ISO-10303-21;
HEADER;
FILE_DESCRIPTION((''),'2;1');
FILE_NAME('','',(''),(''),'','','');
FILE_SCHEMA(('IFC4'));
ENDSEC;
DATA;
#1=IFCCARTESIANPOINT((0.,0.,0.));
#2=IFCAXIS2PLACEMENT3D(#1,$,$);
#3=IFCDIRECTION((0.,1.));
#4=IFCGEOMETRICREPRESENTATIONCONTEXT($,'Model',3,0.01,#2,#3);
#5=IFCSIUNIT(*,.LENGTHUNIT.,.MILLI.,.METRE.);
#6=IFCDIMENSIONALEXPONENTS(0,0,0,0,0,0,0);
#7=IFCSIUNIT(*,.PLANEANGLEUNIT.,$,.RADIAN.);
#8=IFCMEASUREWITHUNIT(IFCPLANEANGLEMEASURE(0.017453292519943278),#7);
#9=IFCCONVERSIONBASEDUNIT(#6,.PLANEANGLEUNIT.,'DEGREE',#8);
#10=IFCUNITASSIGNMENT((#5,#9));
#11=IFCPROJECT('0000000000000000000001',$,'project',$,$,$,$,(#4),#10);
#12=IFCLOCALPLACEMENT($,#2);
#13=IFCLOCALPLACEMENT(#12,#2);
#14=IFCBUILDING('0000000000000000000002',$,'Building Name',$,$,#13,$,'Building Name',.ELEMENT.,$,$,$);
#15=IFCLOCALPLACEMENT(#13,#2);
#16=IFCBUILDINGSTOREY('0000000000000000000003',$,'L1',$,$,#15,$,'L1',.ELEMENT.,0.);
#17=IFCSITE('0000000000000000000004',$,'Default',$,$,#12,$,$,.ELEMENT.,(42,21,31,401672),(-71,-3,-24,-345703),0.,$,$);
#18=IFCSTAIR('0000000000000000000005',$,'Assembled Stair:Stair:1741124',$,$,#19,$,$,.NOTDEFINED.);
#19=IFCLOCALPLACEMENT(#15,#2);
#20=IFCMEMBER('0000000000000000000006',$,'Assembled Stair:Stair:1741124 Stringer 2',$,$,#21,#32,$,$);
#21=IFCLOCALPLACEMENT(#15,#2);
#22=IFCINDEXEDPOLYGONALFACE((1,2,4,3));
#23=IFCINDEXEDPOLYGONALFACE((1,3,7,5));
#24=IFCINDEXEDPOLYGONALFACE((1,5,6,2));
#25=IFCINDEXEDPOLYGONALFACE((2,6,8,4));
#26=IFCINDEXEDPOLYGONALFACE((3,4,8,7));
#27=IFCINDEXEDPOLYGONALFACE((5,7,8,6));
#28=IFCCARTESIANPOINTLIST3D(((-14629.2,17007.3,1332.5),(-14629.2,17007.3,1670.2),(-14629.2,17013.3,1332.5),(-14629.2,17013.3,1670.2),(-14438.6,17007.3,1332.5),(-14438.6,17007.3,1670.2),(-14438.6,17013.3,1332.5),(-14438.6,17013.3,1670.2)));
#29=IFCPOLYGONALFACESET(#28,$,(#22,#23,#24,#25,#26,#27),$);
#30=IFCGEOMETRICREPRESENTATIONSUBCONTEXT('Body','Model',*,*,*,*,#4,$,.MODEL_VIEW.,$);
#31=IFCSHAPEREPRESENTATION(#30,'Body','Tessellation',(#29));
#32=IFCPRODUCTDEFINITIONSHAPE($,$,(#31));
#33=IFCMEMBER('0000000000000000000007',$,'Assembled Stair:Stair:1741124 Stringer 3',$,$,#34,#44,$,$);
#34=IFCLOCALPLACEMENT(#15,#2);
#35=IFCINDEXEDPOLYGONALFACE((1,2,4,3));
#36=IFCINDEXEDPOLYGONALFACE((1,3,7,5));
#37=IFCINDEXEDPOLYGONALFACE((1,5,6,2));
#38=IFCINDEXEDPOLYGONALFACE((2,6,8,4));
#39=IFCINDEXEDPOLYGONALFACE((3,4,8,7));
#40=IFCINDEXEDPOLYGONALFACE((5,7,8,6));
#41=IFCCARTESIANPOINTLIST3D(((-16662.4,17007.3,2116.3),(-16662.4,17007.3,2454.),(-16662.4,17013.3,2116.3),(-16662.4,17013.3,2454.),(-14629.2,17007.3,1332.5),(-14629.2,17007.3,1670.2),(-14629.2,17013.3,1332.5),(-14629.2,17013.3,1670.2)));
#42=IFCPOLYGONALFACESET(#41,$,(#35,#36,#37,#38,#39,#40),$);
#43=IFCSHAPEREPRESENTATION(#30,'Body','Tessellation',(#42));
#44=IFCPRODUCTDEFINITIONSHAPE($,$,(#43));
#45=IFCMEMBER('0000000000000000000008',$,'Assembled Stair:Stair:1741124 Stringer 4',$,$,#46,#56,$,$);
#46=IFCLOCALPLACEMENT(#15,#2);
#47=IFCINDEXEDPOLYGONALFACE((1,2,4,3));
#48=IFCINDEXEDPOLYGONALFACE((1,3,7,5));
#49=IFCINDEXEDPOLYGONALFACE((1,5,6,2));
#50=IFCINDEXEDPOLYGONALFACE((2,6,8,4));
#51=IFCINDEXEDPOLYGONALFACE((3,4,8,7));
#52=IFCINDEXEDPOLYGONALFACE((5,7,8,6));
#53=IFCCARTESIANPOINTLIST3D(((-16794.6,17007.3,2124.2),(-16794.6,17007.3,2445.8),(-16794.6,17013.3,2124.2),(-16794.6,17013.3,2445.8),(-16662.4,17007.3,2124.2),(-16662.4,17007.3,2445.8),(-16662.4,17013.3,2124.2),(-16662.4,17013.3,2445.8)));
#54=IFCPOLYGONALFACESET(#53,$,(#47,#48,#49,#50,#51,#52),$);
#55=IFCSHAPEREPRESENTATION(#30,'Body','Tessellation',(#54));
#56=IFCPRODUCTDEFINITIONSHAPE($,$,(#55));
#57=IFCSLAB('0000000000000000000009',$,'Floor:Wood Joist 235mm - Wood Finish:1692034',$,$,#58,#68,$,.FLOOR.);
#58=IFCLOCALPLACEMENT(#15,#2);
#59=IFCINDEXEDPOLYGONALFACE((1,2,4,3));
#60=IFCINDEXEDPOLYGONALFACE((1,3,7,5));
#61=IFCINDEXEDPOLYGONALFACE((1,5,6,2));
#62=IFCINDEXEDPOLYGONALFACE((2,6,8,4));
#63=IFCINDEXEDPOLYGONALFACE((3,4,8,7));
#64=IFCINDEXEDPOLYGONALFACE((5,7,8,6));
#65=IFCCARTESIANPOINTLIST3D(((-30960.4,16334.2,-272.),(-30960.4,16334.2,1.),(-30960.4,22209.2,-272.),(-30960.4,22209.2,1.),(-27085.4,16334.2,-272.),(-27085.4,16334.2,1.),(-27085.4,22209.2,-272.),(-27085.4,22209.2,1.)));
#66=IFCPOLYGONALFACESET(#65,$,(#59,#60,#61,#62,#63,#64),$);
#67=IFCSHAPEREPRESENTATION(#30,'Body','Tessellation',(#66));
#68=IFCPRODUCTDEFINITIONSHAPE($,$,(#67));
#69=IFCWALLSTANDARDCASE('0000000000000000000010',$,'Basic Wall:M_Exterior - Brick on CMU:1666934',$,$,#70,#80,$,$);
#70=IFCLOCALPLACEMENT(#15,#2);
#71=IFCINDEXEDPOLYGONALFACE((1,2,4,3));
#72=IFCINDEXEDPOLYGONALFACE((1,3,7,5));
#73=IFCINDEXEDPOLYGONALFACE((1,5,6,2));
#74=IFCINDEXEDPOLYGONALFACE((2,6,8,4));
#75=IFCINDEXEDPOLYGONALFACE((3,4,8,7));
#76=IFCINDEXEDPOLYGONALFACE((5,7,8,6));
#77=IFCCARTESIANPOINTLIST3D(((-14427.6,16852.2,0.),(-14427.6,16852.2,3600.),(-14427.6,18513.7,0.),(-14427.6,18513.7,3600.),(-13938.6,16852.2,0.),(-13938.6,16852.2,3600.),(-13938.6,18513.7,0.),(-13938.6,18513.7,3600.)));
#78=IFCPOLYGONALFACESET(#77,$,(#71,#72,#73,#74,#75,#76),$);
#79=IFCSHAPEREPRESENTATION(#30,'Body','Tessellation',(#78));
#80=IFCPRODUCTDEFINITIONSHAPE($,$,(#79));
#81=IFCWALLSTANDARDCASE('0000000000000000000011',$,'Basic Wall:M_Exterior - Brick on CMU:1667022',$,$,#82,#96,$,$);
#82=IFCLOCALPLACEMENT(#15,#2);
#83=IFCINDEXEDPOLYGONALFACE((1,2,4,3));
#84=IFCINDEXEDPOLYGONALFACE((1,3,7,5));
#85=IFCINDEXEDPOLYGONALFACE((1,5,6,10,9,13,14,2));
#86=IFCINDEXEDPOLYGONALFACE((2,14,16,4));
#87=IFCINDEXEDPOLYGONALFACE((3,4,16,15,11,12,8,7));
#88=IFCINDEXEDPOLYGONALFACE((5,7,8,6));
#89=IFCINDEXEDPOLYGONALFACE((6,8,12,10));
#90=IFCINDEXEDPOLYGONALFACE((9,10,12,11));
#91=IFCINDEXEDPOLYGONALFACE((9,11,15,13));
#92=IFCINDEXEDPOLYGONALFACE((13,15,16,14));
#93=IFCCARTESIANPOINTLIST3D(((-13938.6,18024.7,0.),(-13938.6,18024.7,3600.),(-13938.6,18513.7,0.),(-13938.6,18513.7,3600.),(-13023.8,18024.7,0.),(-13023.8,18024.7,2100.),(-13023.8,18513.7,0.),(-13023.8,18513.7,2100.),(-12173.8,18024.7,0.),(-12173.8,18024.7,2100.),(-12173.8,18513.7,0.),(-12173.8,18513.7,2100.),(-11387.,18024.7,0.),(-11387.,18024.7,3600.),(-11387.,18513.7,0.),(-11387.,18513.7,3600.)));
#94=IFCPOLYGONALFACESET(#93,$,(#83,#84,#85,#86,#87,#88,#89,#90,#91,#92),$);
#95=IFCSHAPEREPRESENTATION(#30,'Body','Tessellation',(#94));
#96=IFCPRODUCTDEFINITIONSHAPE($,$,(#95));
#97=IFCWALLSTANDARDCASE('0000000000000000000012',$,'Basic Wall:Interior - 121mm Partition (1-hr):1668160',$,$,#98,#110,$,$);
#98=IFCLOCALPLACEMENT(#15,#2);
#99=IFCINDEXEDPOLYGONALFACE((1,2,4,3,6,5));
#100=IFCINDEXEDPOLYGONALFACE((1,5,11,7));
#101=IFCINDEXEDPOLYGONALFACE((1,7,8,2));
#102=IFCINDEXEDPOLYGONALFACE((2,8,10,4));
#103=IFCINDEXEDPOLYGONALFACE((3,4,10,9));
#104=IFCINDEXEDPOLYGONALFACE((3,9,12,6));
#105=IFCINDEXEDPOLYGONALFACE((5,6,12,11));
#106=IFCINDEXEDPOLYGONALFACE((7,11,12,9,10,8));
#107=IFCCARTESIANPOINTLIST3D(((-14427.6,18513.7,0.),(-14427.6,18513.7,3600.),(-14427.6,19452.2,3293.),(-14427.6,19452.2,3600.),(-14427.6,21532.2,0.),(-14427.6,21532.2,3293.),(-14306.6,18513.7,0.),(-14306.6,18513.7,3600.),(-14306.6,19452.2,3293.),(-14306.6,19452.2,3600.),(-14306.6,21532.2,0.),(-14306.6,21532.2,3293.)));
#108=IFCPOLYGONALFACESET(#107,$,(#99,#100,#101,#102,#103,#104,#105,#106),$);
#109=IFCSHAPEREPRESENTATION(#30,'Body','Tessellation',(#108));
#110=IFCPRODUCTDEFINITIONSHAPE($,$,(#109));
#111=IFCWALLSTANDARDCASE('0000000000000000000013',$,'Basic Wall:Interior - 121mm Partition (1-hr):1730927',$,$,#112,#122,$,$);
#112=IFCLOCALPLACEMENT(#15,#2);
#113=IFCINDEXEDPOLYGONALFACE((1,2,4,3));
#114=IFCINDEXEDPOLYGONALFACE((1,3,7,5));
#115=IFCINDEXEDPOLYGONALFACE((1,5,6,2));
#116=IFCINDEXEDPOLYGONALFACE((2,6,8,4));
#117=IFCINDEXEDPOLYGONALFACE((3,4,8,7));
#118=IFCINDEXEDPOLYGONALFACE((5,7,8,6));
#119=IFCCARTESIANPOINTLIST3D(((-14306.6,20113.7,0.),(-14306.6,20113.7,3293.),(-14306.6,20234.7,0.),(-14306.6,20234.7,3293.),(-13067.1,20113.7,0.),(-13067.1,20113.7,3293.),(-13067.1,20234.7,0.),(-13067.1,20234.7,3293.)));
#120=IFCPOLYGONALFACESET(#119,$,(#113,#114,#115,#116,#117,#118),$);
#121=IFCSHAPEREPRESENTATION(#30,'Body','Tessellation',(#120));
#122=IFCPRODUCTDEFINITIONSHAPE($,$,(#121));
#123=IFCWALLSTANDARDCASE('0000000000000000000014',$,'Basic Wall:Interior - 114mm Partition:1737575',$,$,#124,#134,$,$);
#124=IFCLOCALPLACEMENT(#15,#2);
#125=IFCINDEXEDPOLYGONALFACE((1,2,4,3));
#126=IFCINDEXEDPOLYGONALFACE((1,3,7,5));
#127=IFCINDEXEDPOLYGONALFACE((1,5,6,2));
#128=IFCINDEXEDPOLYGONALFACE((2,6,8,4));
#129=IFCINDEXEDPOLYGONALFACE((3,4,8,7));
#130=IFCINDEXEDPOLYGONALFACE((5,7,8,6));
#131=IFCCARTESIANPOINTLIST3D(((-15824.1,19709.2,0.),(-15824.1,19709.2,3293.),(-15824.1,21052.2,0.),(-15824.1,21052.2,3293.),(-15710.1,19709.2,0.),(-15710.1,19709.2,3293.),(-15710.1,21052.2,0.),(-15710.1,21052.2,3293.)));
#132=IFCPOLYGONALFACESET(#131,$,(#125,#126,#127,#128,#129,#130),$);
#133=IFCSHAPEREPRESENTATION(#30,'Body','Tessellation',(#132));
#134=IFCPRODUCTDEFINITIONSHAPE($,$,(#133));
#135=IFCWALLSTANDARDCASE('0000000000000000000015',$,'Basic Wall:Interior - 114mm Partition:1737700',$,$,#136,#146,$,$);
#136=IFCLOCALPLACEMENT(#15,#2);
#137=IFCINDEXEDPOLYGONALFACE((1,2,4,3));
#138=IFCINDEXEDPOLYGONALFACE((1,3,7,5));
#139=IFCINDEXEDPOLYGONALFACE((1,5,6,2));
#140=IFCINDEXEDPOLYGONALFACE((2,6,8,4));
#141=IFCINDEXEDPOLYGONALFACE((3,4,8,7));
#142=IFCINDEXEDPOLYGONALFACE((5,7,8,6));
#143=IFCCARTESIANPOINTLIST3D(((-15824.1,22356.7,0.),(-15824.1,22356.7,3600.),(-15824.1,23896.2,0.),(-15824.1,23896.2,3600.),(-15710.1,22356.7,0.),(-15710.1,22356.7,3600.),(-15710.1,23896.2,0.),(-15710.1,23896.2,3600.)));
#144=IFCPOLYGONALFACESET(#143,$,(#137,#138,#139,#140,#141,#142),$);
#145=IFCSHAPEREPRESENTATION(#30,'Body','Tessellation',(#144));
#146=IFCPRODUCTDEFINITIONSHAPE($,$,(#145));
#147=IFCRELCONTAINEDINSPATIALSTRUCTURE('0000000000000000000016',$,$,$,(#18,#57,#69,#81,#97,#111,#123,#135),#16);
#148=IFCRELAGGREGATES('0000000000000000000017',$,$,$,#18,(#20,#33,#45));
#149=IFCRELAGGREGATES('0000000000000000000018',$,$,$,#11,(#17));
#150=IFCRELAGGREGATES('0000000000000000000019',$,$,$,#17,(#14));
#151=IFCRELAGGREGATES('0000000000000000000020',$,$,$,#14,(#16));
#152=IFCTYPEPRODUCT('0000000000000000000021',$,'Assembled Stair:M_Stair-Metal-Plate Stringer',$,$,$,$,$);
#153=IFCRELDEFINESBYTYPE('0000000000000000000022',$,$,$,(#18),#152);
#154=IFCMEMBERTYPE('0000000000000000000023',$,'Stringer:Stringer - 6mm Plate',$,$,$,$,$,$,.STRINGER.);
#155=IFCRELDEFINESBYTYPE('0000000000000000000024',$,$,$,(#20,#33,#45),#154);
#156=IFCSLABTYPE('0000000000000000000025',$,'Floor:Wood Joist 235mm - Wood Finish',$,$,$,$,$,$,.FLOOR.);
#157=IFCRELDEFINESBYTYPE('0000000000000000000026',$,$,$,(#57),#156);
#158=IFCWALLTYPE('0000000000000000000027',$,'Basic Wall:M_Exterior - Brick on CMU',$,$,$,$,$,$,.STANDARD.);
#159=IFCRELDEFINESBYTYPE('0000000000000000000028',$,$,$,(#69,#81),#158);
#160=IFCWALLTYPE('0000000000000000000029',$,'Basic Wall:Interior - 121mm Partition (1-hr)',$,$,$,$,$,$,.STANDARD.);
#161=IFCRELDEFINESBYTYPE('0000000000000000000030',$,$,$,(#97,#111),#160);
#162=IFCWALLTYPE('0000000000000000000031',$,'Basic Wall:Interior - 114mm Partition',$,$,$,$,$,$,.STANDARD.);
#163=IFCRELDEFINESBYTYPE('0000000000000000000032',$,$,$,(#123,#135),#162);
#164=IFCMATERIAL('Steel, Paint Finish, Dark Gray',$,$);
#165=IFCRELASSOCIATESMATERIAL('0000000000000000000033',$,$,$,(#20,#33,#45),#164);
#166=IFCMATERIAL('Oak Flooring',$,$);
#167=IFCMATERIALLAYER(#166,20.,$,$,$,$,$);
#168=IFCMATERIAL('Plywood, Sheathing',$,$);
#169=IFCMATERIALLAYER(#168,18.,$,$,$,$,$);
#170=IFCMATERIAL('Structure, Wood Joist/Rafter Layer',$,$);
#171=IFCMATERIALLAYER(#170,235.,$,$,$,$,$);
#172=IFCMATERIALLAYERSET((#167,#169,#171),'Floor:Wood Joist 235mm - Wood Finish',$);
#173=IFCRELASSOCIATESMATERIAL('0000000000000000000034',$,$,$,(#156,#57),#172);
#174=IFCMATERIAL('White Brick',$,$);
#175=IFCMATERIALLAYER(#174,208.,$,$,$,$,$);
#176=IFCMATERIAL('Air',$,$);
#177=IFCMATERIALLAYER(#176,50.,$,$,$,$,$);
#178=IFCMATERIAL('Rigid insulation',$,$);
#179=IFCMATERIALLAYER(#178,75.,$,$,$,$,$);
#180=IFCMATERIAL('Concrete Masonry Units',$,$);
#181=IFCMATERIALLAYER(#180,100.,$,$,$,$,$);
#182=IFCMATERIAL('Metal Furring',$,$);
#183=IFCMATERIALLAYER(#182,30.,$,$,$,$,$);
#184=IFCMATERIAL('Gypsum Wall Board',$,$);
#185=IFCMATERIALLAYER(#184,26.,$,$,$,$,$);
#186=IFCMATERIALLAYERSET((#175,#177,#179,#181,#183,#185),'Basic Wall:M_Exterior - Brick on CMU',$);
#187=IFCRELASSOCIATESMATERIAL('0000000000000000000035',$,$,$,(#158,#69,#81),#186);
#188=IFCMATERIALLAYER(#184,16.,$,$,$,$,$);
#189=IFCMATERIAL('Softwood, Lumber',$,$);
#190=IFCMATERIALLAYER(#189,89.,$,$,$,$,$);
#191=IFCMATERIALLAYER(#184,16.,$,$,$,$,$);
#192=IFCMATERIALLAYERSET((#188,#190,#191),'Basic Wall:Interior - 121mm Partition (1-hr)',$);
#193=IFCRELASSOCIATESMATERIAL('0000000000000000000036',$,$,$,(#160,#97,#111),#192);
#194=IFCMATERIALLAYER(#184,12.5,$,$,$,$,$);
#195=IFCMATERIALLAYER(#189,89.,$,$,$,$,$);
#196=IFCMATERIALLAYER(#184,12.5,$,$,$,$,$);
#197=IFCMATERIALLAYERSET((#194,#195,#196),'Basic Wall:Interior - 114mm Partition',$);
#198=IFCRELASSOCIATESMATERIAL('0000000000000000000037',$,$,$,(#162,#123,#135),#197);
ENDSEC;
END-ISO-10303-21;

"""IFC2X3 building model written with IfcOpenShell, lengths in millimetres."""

from ifc_helpers import new_model, entity, si_unit, converted_unit, direction, frame, frame_2d, origin, place, context, subcontext, project, spatial, polyline, rectangle, outline, extrude, clip, bounded_halfspace, material, layer, layer_set, layer_usage, type_object, element, aggregate, save


model = new_model("IFC2X3")

# Units and contexts
model_context = context("Model", 3, precision=0.01, world=origin(), true_north=direction((0.0, 1.0)))
body_context = subcontext(model_context, "Body", "Model", "MODEL_VIEW")
ifc_project = project(units=[si_unit("LENGTHUNIT", "METRE", prefix="MILLI"), converted_unit("PLANEANGLEUNIT", "DEGREE", entity("IfcPlaneAngleMeasure", 0.017453292519943278), si_unit("PLANEANGLEUNIT", "RADIAN"), dimensions=[0, 0, 0, 0, 0, 0, 0])], contexts=[model_context])

# Site, building, storey
site_placement = place(None, origin())
site = spatial("IfcSite", under=ifc_project, at=site_placement, Name="Default", CompositionType="ELEMENT", RefLatitude=(42, 21, 31, 401672), RefLongitude=(-71, -3, -24, -345703), RefElevation=0.0)
building_placement = place(site_placement, origin())
building = spatial("IfcBuilding", under=site, at=building_placement, Name="Building Name", LongName="Building Name", CompositionType="ELEMENT")
storey_placement = place(building_placement, origin())
storey = spatial("IfcBuildingStorey", under=building, at=storey_placement, Name="L1", LongName="L1", CompositionType="ELEMENT", Elevation=0.0)

# Stair, members
type_product = type_object("IfcTypeProduct", Name="Assembled Stair:M_Stair-Metal-Plate Stringer")
stair_placement = place(storey_placement, origin())
stair = element("IfcStair", 1, at=stair_placement, inside=storey, type_object=type_product, Name="Assembled Stair:Stair:1741124", ShapeType="NOTDEFINED")
ifc_material_1 = material(Name="Steel, Paint Finish, Dark Gray")
member_type = type_object("IfcMemberType", Name="Stringer:Stringer - 6mm Plate", PredefinedType="STRINGER")
member_1_placement = place(stair_placement, origin())
member_1 = element("IfcMember", 2, at=member_1_placement, type_object=member_type, material=ifc_material_1, Name="Assembled Stair:Stair:1741124 Stringer 2", context=body_context, shape_type="SweptSolid", body=[
    extrude(rectangle(XDim=190.6, YDim=6.0, at=frame_2d((0.0, 0.0), x_axis=(1.0, 0.0))), frame((-14533.9, 17010.3, 1332.5), z_axis=(0.0, 0.0, 1.0), x_axis=(-1.0, 0.0, 0.0)), (0.0, 0.0, 1.0), 337.7),
])
member_2_placement = place(stair_placement, origin())
member_2 = element("IfcMember", 3, at=member_2_placement, type_object=member_type, material=ifc_material_1, Name="Assembled Stair:Stair:1741124 Stringer 3", context=body_context, shape_type="SweptSolid", body=[
    extrude(outline(polyline([(-1150.2, -157.5), (1028.8, -157.5), (1150.2, 157.5), (-1028.8, 157.5), (-1150.2, -157.5)])), frame((-15645.8, 17007.3, 1893.3), z_axis=(0.0, 1.0, 0.0), x_axis=(-0.933076, 0.0, 0.35968)), (0.0, 0.0, 1.0), 6.0),
])
member_3_placement = place(stair_placement, origin())
member_3 = element("IfcMember", 4, at=member_3_placement, type_object=member_type, material=ifc_material_1, Name="Assembled Stair:Stair:1741124 Stringer 4", context=body_context, shape_type="SweptSolid", body=[
    extrude(rectangle(XDim=132.2, YDim=6.0, at=frame_2d((0.0, 0.0), x_axis=(1.0, 0.0))), frame((-16728.5, 17010.3, 2124.2), z_axis=(0.0, 0.0, 1.0), x_axis=(-1.0, 0.0, 0.0)), (0.0, 0.0, 1.0), 321.5),
])
aggregate(stair, [member_1, member_2, member_3])

# Slab
ifc_material_2 = material(Name="Oak Flooring")
ifc_layer_1 = layer(ifc_material_2, 20.0)
ifc_material_3 = material(Name="Plywood, Sheathing")
ifc_layer_2 = layer(ifc_material_3, 18.0)
ifc_material_4 = material(Name="Structure, Wood Joist/Rafter Layer")
ifc_layer_3 = layer(ifc_material_4, 235.0)
ifc_layer_set_1 = layer_set([ifc_layer_1, ifc_layer_2, ifc_layer_3], Name="Floor:Wood Joist 235mm - Wood Finish")
ifc_layer_usage_1 = layer_usage(ifc_layer_set_1, "AXIS3", "POSITIVE", 0.0)
slab_type_1 = type_object("IfcSlabType", Name="Floor:Wood Joist 235mm - Wood Finish", PredefinedType="FLOOR", material=ifc_layer_set_1)
slab_1_placement = place(storey_placement, origin())
element("IfcSlab", 5, at=slab_1_placement, inside=storey, type_object=slab_type_1, material=ifc_layer_usage_1, Name="Floor:Wood Joist 235mm - Wood Finish:1692034", PredefinedType="FLOOR", context=body_context, shape_type="SweptSolid", body=[
    extrude(rectangle(XDim=5875.0, YDim=3875.0, at=frame_2d((0.0, 0.0), x_axis=(1.0, 0.0))), frame((-29022.9, 19271.7, 1.0), z_axis=(0.0, 0.0, -1.0), x_axis=(0.0, 1.0, 0.0)), (0.0, 0.0, 1.0), 273.0),
])

# Wall
ifc_material_5 = material(Name="White Brick")
ifc_layer_4 = layer(ifc_material_5, 208.0)
ifc_material_6 = material(Name="Air")
ifc_layer_5 = layer(ifc_material_6, 50.0)
ifc_material_7 = material(Name="Rigid insulation")
ifc_layer_6 = layer(ifc_material_7, 75.0)
ifc_material_8 = material(Name="Concrete Masonry Units")
ifc_layer_7 = layer(ifc_material_8, 100.0)
ifc_material_9 = material(Name="Metal Furring")
ifc_layer_8 = layer(ifc_material_9, 30.0)
ifc_material_10 = material(Name="Gypsum Wall Board")
ifc_layer_9 = layer(ifc_material_10, 26.0)
ifc_layer_set_2 = layer_set([ifc_layer_4, ifc_layer_5, ifc_layer_6, ifc_layer_7, ifc_layer_8, ifc_layer_9], Name="Basic Wall:M_Exterior - Brick on CMU")
ifc_layer_usage_2 = layer_usage(ifc_layer_set_2, "AXIS2", "POSITIVE", -244.5)
wall_type_1 = type_object("IfcWallType", Name="Basic Wall:M_Exterior - Brick on CMU", PredefinedType="STANDARD", material=ifc_layer_set_2)
wall_1_placement = place(storey_placement, frame((-14183.1, 16852.2, 0.0), z_axis=(0.0, 0.0, 1.0), x_axis=(0.0, 1.0, 0.0)))
element("IfcWallStandardCase", 6, at=wall_1_placement, inside=storey, type_object=wall_type_1, material=ifc_layer_usage_2, Name="Basic Wall:M_Exterior - Brick on CMU:1666934", context=body_context, shape_type="SweptSolid", body=[
    extrude(rectangle(XDim=1661.5, YDim=489.0, at=frame_2d((830.8, 0.0), x_axis=(-1.0, 0.0))), origin(), (0.0, 0.0, 1.0), 3600.0),
])

# Wall, opening
ifc_layer_usage_3 = layer_usage(ifc_layer_set_2, "AXIS2", "POSITIVE", -244.5)
wall_2_placement = place(storey_placement, frame((-13938.6, 18269.2, 0.0)))
wall_2 = element("IfcWallStandardCase", 7, at=wall_2_placement, inside=storey, type_object=wall_type_1, material=ifc_layer_usage_3, Name="Basic Wall:M_Exterior - Brick on CMU:1667022", context=body_context, shape_type="SweptSolid", body=[
    extrude(rectangle(XDim=2551.6, YDim=489.0, at=frame_2d((1275.8, 0.0), x_axis=(-1.0, 0.0))), origin(), (0.0, 0.0, 1.0), 3600.0),
])
opening_1_placement = place(wall_2_placement, frame((914.9, -244.5, 0.0)))
element("IfcOpeningElement", 8, at=opening_1_placement, cuts=wall_2, ObjectType="Opening", context=body_context, shape_type="SweptSolid", body=[
    extrude(rectangle(XDim=2100.0, YDim=850.0, at=frame_2d((1050.0, 425.0), x_axis=(1.0, 0.0))), frame((0.0, 0.0, 0.0), z_axis=(0.0, 1.0, 0.0), x_axis=(0.0, 0.0, 1.0)), (0.0, 0.0, 1.0), 489.0),
])

# Walls
ifc_layer_10 = layer(ifc_material_10, 16.0)
ifc_material_11 = material(Name="Softwood, Lumber")
ifc_layer_11 = layer(ifc_material_11, 89.0)
ifc_layer_12 = layer(ifc_material_10, 16.0)
ifc_layer_set_3 = layer_set([ifc_layer_10, ifc_layer_11, ifc_layer_12], Name="Basic Wall:Interior - 121mm Partition (1-hr)")
ifc_layer_usage_4 = layer_usage(ifc_layer_set_3, "AXIS2", "NEGATIVE", 60.5)
wall_type_2 = type_object("IfcWallType", Name="Basic Wall:Interior - 121mm Partition (1-hr)", PredefinedType="STANDARD", material=ifc_layer_set_3)
wall_3_placement = place(storey_placement, frame((-14367.1, 21532.2, 0.0), z_axis=(0.0, 0.0, 1.0), x_axis=(0.0, -1.0, 0.0)))
element("IfcWallStandardCase", 9, at=wall_3_placement, inside=storey, type_object=wall_type_2, material=ifc_layer_usage_4, Name="Basic Wall:Interior - 121mm Partition (1-hr):1668160", context=body_context, shape_type="Clipping", body=[
    clip(extrude(rectangle(XDim=3018.5, YDim=121.0, at=frame_2d((1509.2, 0.0), x_axis=(-1.0, 0.0))), origin(), (0.0, 0.0, 1.0), 3600.0), bounded_halfspace(frame((0.0, -60.5, 3293.0), z_axis=(0.0, 0.0, -1.0), x_axis=(1.0, 0.0, 0.0)), True, frame((0.0, -60.5, 3293.0)), polyline([(0.0, 0.0), (2080.0, 0.0), (2080.0, 121.0), (1418.5, 121.0), (1297.5, 121.0), (0.0, 121.0), (0.0, 0.0)]))),
])
ifc_layer_usage_5 = layer_usage(ifc_layer_set_3, "AXIS2", "NEGATIVE", 60.5)
wall_4_placement = place(storey_placement, frame((-13067.1, 20174.2, 0.0), z_axis=(0.0, 0.0, 1.0), x_axis=(-1.0, 0.0, 0.0)))
element("IfcWallStandardCase", 10, at=wall_4_placement, inside=storey, type_object=wall_type_2, material=ifc_layer_usage_5, Name="Basic Wall:Interior - 121mm Partition (1-hr):1730927", context=body_context, shape_type="Clipping", body=[
    clip(extrude(rectangle(XDim=1239.5, YDim=121.0, at=frame_2d((619.7, 0.0), x_axis=(-1.0, 0.0))), origin(), (0.0, 0.0, 1.0), 3293.0), bounded_halfspace(frame((0.0, -60.5, 3293.0), z_axis=(0.0, 0.0, -1.0), x_axis=(0.0, 1.0, 0.0)), True, frame((0.0, -60.5, 3293.0)), polyline([(0.0, 0.0), (1239.5, 0.0), (1239.5, 121.0), (0.0, 121.0), (0.0, 0.0)]))),
])
ifc_layer_13 = layer(ifc_material_10, 12.5)
ifc_layer_14 = layer(ifc_material_11, 89.0)
ifc_layer_15 = layer(ifc_material_10, 12.5)
ifc_layer_set_4 = layer_set([ifc_layer_13, ifc_layer_14, ifc_layer_15], Name="Basic Wall:Interior - 114mm Partition")
ifc_layer_usage_6 = layer_usage(ifc_layer_set_4, "AXIS2", "NEGATIVE", 57.0)
wall_type_3 = type_object("IfcWallType", Name="Basic Wall:Interior - 114mm Partition", PredefinedType="STANDARD", material=ifc_layer_set_4)
wall_5_placement = place(storey_placement, frame((-15767.1, 19709.2, 0.0), z_axis=(0.0, 0.0, 1.0), x_axis=(0.0, 1.0, 0.0)))
element("IfcWallStandardCase", 11, at=wall_5_placement, inside=storey, type_object=wall_type_3, material=ifc_layer_usage_6, Name="Basic Wall:Interior - 114mm Partition:1737575", context=body_context, shape_type="Clipping", body=[
    clip(extrude(rectangle(XDim=1343.0, YDim=114.0, at=frame_2d((671.5, 0.0), x_axis=(-1.0, 0.0))), origin(), (0.0, 0.0, 1.0), 3293.0), bounded_halfspace(frame((0.0, -57.0, 3293.0), z_axis=(0.0, 0.0, -1.0), x_axis=(-1.0, 0.0, 0.0)), True, frame((0.0, -57.0, 3293.0)), polyline([(0.0, 0.0), (1343.0, 0.0), (1343.0, 114.0), (0.0, 114.0), (0.0, 0.0)]))),
])
ifc_layer_usage_7 = layer_usage(ifc_layer_set_4, "AXIS2", "NEGATIVE", 57.0)
wall_6_placement = place(storey_placement, frame((-15767.1, 22356.7, 0.0), z_axis=(0.0, 0.0, 1.0), x_axis=(0.0, 1.0, 0.0)))
element("IfcWallStandardCase", 12, at=wall_6_placement, inside=storey, type_object=wall_type_3, material=ifc_layer_usage_7, Name="Basic Wall:Interior - 114mm Partition:1737700", context=body_context, shape_type="SweptSolid", body=[
    extrude(rectangle(XDim=1539.5, YDim=114.0, at=frame_2d((769.8, 0.0), x_axis=(-1.0, 0.0))), origin(), (0.0, 0.0, 1.0), 3600.0),
])

save(model, "model.ifc")
